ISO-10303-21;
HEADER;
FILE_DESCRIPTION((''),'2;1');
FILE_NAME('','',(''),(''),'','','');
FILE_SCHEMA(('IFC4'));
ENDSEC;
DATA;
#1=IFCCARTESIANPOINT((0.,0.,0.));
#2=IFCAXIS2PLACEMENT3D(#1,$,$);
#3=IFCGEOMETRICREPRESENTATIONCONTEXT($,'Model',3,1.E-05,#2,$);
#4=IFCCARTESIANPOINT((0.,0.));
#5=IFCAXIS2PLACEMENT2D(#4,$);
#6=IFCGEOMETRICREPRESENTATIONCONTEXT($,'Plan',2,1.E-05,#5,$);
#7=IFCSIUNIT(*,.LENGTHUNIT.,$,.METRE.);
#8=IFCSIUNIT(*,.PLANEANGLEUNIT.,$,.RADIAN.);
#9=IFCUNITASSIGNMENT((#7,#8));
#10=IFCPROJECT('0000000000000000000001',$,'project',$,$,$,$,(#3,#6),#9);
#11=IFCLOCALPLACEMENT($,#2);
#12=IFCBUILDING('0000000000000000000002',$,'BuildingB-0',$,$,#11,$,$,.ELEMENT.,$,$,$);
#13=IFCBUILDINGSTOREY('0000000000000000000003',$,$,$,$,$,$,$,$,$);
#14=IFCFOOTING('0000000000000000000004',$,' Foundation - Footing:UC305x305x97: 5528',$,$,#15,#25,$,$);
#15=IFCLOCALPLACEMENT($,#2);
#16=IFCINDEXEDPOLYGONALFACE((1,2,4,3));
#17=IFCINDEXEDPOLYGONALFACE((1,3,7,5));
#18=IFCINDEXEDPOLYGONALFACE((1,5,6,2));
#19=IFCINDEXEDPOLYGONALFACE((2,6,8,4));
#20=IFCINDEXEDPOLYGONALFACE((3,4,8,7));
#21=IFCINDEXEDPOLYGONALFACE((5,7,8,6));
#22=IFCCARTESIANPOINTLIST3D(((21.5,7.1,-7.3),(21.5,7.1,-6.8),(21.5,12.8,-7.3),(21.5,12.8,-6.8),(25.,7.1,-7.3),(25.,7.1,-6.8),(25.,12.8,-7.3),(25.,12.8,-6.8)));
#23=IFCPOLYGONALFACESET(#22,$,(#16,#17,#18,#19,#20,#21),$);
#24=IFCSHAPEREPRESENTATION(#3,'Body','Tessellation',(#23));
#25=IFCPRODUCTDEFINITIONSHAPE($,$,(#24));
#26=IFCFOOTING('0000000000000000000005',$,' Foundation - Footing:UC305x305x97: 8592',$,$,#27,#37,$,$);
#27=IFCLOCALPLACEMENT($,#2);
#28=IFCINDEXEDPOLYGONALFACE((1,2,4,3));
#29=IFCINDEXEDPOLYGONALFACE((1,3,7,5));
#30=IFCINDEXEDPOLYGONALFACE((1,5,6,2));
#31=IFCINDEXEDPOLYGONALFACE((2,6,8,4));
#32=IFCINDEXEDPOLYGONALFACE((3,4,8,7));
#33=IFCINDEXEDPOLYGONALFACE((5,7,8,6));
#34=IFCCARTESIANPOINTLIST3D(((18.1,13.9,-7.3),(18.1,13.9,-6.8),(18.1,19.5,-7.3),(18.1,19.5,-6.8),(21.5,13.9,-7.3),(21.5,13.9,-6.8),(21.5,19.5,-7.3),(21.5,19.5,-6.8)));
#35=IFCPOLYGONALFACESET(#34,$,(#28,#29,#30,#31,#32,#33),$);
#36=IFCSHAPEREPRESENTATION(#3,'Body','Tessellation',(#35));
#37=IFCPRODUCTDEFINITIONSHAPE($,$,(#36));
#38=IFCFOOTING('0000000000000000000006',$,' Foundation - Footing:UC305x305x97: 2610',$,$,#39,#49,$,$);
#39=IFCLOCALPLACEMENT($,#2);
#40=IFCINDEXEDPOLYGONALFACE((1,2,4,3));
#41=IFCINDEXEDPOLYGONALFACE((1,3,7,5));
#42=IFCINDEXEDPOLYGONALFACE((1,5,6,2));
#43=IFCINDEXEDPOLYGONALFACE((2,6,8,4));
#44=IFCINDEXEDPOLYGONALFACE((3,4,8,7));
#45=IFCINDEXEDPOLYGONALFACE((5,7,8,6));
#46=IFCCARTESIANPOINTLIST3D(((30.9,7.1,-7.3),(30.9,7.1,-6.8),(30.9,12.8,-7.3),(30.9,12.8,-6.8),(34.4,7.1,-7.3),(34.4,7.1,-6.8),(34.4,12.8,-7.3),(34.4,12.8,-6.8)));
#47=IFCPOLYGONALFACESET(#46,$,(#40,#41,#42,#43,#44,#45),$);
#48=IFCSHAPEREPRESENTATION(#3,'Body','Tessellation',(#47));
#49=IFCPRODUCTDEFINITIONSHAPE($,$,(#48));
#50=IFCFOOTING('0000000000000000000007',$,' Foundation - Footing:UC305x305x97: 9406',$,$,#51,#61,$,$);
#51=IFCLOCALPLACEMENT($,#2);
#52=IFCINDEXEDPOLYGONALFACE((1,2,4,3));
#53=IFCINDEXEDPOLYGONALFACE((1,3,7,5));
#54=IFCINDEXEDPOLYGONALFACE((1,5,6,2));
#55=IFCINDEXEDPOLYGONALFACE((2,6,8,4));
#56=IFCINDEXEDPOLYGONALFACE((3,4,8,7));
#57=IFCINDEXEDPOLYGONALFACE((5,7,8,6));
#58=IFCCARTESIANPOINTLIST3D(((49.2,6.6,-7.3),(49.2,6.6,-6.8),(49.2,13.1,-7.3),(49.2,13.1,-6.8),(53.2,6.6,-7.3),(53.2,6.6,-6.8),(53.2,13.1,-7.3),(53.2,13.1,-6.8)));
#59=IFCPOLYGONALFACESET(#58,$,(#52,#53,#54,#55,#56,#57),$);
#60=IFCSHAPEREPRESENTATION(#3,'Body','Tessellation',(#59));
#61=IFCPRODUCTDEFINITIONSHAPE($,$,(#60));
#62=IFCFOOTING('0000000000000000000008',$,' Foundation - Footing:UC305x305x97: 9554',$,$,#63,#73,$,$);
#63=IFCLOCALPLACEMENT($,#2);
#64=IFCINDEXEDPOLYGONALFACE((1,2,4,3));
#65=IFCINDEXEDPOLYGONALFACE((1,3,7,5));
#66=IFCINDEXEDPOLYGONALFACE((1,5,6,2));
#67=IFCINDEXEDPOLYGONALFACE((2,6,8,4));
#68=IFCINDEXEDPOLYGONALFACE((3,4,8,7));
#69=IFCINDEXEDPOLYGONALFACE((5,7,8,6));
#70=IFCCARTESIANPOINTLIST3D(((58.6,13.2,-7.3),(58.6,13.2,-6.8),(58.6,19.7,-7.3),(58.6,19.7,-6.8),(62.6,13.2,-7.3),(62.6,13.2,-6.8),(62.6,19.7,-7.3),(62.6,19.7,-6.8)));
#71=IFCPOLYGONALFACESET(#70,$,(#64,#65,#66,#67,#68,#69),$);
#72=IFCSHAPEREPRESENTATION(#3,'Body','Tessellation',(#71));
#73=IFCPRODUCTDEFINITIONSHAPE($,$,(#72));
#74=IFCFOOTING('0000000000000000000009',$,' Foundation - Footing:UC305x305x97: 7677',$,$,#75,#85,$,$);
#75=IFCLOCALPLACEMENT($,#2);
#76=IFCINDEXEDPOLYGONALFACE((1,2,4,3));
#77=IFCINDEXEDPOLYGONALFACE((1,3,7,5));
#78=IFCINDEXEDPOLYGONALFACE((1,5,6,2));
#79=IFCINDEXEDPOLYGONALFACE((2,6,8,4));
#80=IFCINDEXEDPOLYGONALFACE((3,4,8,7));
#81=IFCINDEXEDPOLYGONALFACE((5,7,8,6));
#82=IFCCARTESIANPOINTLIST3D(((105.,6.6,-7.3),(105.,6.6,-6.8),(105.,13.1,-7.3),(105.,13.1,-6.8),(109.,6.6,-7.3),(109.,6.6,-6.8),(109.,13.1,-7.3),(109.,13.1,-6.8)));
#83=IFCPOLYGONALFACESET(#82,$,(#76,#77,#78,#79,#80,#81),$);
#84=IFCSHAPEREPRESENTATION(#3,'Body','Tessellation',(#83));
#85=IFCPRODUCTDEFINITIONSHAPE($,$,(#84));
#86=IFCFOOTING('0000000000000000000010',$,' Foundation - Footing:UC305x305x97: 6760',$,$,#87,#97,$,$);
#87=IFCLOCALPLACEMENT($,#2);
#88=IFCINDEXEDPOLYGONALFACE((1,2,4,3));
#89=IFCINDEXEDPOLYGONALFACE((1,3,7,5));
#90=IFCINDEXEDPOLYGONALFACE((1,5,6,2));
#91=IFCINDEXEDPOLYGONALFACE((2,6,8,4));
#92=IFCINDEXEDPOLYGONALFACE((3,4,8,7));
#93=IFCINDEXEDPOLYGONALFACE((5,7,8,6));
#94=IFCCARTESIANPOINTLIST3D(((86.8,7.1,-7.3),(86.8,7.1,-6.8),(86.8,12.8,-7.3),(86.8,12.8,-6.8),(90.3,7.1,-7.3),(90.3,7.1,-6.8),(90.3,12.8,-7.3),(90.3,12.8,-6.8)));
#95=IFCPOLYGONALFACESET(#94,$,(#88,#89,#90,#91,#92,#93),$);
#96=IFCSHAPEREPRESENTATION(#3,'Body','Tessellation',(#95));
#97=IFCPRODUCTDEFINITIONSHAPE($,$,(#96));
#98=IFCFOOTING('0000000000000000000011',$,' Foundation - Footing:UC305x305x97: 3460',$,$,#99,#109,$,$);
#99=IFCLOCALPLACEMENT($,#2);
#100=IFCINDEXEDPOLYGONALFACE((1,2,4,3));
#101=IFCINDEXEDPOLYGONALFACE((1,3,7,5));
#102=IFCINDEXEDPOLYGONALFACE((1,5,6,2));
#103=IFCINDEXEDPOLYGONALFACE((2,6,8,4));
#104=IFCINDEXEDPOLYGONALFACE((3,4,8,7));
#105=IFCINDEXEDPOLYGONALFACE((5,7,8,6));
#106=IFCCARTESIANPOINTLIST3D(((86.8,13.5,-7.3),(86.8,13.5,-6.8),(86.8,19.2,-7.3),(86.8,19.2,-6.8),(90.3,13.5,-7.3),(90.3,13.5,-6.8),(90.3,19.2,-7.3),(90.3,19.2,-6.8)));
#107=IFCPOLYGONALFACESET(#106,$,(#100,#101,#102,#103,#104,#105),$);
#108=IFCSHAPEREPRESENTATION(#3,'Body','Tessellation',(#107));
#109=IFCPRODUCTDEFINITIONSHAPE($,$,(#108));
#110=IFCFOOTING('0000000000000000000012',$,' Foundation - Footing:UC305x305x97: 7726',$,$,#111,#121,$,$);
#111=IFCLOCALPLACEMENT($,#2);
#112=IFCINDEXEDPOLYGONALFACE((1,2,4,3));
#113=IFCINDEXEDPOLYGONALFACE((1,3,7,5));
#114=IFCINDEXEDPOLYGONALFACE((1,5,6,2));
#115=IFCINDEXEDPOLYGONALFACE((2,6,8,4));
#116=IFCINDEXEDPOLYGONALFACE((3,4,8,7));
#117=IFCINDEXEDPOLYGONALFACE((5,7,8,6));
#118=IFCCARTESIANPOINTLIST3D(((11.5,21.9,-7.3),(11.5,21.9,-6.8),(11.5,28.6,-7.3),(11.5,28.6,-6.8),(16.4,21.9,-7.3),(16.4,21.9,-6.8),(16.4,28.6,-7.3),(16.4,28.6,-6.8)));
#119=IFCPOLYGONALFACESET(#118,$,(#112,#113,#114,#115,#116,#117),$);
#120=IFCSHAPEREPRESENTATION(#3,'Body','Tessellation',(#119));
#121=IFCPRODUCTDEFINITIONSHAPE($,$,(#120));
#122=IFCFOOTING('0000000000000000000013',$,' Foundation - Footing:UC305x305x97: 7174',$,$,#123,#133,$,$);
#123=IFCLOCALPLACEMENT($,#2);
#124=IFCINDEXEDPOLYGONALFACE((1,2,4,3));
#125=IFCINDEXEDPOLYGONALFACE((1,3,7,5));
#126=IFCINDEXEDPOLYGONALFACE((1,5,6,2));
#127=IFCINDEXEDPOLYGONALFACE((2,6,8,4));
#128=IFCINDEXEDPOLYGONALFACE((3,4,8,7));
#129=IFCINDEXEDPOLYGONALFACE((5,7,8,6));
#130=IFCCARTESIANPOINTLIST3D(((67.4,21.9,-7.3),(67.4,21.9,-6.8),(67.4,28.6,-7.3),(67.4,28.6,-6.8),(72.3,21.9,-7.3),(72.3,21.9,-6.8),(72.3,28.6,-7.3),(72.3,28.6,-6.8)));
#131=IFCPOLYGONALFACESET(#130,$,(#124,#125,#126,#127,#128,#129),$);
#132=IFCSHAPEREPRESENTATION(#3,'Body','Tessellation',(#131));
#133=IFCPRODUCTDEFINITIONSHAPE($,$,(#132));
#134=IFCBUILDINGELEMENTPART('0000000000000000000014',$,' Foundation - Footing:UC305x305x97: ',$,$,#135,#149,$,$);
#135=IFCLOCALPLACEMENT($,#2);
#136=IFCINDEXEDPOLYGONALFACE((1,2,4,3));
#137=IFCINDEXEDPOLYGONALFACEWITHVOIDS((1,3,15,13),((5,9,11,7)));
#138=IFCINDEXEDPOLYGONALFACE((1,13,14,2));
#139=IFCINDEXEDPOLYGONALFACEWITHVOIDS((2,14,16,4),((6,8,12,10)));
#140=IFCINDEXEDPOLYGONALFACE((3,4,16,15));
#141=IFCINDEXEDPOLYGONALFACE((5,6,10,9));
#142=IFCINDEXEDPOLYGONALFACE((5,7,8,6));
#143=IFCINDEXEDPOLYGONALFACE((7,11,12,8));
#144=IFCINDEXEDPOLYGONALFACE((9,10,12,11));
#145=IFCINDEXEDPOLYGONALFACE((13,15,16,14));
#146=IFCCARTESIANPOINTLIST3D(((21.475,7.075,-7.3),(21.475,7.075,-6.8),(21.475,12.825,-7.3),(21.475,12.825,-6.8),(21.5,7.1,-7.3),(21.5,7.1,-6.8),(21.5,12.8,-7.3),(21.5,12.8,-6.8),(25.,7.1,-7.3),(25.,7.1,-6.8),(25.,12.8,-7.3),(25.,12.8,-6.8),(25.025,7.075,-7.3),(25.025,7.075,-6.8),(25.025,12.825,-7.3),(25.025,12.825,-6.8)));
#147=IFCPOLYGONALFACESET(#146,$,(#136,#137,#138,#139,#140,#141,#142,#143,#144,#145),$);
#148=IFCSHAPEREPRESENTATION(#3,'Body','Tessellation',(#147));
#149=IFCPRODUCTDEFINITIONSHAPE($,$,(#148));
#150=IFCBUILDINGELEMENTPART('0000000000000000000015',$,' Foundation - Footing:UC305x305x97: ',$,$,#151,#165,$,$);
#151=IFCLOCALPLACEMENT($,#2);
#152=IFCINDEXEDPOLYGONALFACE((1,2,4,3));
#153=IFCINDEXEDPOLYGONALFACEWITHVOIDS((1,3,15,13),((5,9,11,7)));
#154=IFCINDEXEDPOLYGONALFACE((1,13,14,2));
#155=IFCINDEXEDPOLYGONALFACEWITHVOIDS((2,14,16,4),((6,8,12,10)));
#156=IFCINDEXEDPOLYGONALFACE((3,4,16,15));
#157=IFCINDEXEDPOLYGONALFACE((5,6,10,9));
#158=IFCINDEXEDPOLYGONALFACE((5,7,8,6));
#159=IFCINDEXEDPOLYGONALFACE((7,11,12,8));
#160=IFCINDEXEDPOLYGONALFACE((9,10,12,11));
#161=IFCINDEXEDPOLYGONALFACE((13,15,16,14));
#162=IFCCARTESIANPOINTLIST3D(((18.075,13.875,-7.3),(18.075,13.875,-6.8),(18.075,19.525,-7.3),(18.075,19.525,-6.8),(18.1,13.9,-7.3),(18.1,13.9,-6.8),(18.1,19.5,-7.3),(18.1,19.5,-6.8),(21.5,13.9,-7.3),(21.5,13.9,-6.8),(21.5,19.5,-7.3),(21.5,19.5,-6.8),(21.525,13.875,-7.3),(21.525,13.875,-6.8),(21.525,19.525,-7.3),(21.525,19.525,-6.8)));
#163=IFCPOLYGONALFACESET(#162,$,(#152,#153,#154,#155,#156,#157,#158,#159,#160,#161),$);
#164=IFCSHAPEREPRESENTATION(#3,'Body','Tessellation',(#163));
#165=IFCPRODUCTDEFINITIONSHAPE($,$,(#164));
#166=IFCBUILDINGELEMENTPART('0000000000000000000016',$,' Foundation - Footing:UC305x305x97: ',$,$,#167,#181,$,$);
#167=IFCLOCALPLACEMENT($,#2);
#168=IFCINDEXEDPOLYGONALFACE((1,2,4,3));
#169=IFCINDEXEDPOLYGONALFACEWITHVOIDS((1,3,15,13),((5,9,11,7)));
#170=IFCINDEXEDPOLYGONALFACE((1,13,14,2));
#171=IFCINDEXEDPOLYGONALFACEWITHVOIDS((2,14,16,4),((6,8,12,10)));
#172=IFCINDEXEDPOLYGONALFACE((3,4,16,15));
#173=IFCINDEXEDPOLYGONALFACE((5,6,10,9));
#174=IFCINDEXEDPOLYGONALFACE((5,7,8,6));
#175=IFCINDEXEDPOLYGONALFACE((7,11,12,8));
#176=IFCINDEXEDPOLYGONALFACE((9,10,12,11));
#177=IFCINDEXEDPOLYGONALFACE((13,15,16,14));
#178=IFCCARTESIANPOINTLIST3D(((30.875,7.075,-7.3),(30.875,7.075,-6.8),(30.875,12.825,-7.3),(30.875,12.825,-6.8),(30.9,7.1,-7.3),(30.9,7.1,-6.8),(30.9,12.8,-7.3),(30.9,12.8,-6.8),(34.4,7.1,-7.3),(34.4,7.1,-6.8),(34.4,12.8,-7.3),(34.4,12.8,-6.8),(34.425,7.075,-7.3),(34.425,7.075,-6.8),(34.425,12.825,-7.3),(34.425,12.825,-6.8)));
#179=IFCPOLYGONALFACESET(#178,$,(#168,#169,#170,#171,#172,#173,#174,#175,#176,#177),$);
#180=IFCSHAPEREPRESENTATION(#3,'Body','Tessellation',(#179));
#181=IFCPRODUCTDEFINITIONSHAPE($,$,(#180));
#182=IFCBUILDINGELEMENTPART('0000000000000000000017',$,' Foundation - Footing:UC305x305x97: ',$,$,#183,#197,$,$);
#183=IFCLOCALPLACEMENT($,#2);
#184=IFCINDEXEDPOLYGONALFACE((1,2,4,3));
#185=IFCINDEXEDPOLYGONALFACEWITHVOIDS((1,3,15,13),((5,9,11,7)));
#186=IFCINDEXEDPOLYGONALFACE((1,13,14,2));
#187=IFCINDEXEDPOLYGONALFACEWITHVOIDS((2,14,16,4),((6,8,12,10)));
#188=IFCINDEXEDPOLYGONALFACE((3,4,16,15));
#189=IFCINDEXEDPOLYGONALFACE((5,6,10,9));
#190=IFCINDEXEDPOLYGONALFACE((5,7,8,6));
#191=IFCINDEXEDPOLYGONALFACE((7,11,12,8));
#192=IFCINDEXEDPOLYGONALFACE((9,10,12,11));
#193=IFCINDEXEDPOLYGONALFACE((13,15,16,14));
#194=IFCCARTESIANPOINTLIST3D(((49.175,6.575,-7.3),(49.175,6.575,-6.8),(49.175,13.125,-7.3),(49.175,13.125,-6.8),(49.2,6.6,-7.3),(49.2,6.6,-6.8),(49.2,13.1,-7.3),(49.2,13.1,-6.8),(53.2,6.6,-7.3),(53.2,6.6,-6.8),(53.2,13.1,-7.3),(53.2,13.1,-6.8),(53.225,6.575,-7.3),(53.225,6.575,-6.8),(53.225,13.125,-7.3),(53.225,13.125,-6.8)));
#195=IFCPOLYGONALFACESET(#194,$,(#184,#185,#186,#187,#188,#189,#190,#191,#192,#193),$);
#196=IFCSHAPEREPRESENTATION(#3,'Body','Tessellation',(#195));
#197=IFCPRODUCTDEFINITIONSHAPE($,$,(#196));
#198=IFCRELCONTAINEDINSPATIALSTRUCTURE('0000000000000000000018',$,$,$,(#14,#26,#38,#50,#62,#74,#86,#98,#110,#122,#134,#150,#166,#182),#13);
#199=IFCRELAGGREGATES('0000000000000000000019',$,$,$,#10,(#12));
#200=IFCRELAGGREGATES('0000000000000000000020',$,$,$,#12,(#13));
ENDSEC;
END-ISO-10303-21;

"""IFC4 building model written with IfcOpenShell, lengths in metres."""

from ifc_helpers import new_model, si_unit, origin, origin_2d, place, context, project, spatial, polyline, outline, extrude, element, save


model = new_model("IFC4")

# Units and contexts
model_context = context("Model", 3, precision=1e-05, world=origin())
plan_context = context("Plan", 2, precision=1e-05, world=origin_2d())
ifc_project = project(units=[si_unit("LENGTHUNIT", "METRE"), si_unit("PLANEANGLEUNIT", "RADIAN")], contexts=[model_context, plan_context])

# Building, storey
building_placement = place(None, origin())
building = spatial("IfcBuilding", under=ifc_project, at=building_placement, Name="BuildingB-0", CompositionType="ELEMENT")
storey = spatial("IfcBuildingStorey", under=building)

# Footings
element("IfcFooting", 1, inside=storey, Name=" Foundation - Footing:UC305x305x97: 5528", context=model_context, shape_type="SweptSolid", body=[
    extrude(outline(polyline([(25.0, 12.8, -7.3), (21.5, 12.8, -7.3), (21.5, 7.1, -7.3), (25.0, 7.1, -7.3), (25.0, 12.8, -7.3)])), None, (0.0, 0.0, 1.0), 0.5),
])
element("IfcFooting", 2, inside=storey, Name=" Foundation - Footing:UC305x305x97: 8592", context=model_context, shape_type="SweptSolid", body=[
    extrude(outline(polyline([(21.5, 19.5, -7.3), (18.1, 19.5, -7.3), (18.1, 13.9, -7.3), (21.5, 13.9, -7.3), (21.5, 19.5, -7.3)])), None, (0.0, 0.0, 1.0), 0.5),
])
element("IfcFooting", 3, inside=storey, Name=" Foundation - Footing:UC305x305x97: 2610", context=model_context, shape_type="SweptSolid", body=[
    extrude(outline(polyline([(34.4, 12.8, -7.3), (30.9, 12.8, -7.3), (30.9, 7.1, -7.3), (34.4, 7.1, -7.3), (34.4, 12.8, -7.3)])), None, (0.0, 0.0, 1.0), 0.5),
])
element("IfcFooting", 4, inside=storey, Name=" Foundation - Footing:UC305x305x97: 9406", context=model_context, shape_type="SweptSolid", body=[
    extrude(outline(polyline([(53.2, 13.1, -7.3), (49.2, 13.1, -7.3), (49.2, 6.6, -7.3), (53.2, 6.6, -7.3), (53.2, 13.1, -7.3)])), None, (0.0, 0.0, 1.0), 0.5),
])
element("IfcFooting", 5, inside=storey, Name=" Foundation - Footing:UC305x305x97: 9554", context=model_context, shape_type="SweptSolid", body=[
    extrude(outline(polyline([(58.6, 19.7, -7.3), (62.6, 19.7, -7.3), (62.6, 13.2, -7.3), (58.6, 13.2, -7.3), (58.6, 19.7, -7.3)])), None, (0.0, 0.0, 1.0), 0.5),
])
element("IfcFooting", 6, inside=storey, Name=" Foundation - Footing:UC305x305x97: 7677", context=model_context, shape_type="SweptSolid", body=[
    extrude(outline(polyline([(109.0, 13.1, -7.3), (105.0, 13.1, -7.3), (105.0, 6.6, -7.3), (109.0, 6.6, -7.3), (109.0, 13.1, -7.3)])), None, (0.0, 0.0, 1.0), 0.5),
])
element("IfcFooting", 7, inside=storey, Name=" Foundation - Footing:UC305x305x97: 6760", context=model_context, shape_type="SweptSolid", body=[
    extrude(outline(polyline([(86.8, 12.8, -7.3), (90.3, 12.8, -7.3), (90.3, 7.1, -7.3), (86.8, 7.1, -7.3), (86.8, 12.8, -7.3)])), None, (0.0, 0.0, 1.0), 0.5),
])
element("IfcFooting", 8, inside=storey, Name=" Foundation - Footing:UC305x305x97: 3460", context=model_context, shape_type="SweptSolid", body=[
    extrude(outline(polyline([(86.8, 19.2, -7.3), (90.3, 19.2, -7.3), (90.3, 13.5, -7.3), (86.8, 13.5, -7.3), (86.8, 19.2, -7.3)])), None, (0.0, 0.0, 1.0), 0.5),
])
element("IfcFooting", 9, inside=storey, Name=" Foundation - Footing:UC305x305x97: 7726", context=model_context, shape_type="SweptSolid", body=[
    extrude(outline(polyline([(16.4, 21.9, -7.3), (16.4, 28.6, -7.3), (11.5, 28.6, -7.3), (11.5, 21.9, -7.3), (16.4, 21.9, -7.3)])), None, (0.0, 0.0, 1.0), 0.5),
])
element("IfcFooting", 10, inside=storey, Name=" Foundation - Footing:UC305x305x97: 7174", context=model_context, shape_type="SweptSolid", body=[
    extrude(outline(polyline([(67.4, 21.9, -7.3), (67.4, 28.6, -7.3), (72.3, 28.6, -7.3), (72.3, 21.9, -7.3), (67.4, 21.9, -7.3)])), None, (0.0, 0.0, 1.0), 0.5),
])

# Building element parts, openings
building_element_part_1 = element("IfcBuildingElementPart", 11, inside=storey, Name=" Foundation - Footing:UC305x305x97: ", context=model_context, shape_type="SweptSolid", body=[
    extrude(outline(polyline([(25.025, 12.825, -7.3), (21.475, 12.825, -7.3), (21.475, 7.075, -7.3), (25.025, 7.075, -7.3), (25.025, 12.825, -7.3)])), None, (0.0, 0.0, 1.0), 0.5),
])
element("IfcOpeningElement", 12, inside=storey, cuts=building_element_part_1, context=model_context, shape_type="SweptSolid", body=[
    extrude(outline(polyline([(25.0, 12.8, -7.3), (21.5, 12.8, -7.3), (21.5, 7.1, -7.3), (25.0, 7.1, -7.3), (25.0, 12.8, -7.3)])), None, (0.0, 0.0, 1.0), 0.5),
])
building_element_part_2 = element("IfcBuildingElementPart", 13, inside=storey, Name=" Foundation - Footing:UC305x305x97: ", context=model_context, shape_type="SweptSolid", body=[
    extrude(outline(polyline([(21.525, 19.525, -7.3), (18.075, 19.525, -7.3), (18.075, 13.875, -7.3), (21.525, 13.875, -7.3), (21.525, 19.525, -7.3)])), None, (0.0, 0.0, 1.0), 0.5),
])
element("IfcOpeningElement", 14, inside=storey, cuts=building_element_part_2, context=model_context, shape_type="SweptSolid", body=[
    extrude(outline(polyline([(21.5, 19.5, -7.3), (18.1, 19.5, -7.3), (18.1, 13.9, -7.3), (21.5, 13.9, -7.3), (21.5, 19.5, -7.3)])), None, (0.0, 0.0, 1.0), 0.5),
])
building_element_part_3 = element("IfcBuildingElementPart", 15, inside=storey, Name=" Foundation - Footing:UC305x305x97: ", context=model_context, shape_type="SweptSolid", body=[
    extrude(outline(polyline([(34.425, 12.825, -7.3), (30.875, 12.825, -7.3), (30.875, 7.075, -7.3), (34.425, 7.075, -7.3), (34.425, 12.825, -7.3)])), None, (0.0, 0.0, 1.0), 0.5),
])
element("IfcOpeningElement", 16, inside=storey, cuts=building_element_part_3, context=model_context, shape_type="SweptSolid", body=[
    extrude(outline(polyline([(34.4, 12.8, -7.3), (30.9, 12.8, -7.3), (30.9, 7.1, -7.3), (34.4, 7.1, -7.3), (34.4, 12.8, -7.3)])), None, (0.0, 0.0, 1.0), 0.5),
])
building_element_part_4 = element("IfcBuildingElementPart", 17, inside=storey, Name=" Foundation - Footing:UC305x305x97: ", context=model_context, shape_type="SweptSolid", body=[
    extrude(outline(polyline([(53.225, 13.125, -7.3), (49.175, 13.125, -7.3), (49.175, 6.575, -7.3), (53.225, 6.575, -7.3), (53.225, 13.125, -7.3)])), None, (0.0, 0.0, 1.0), 0.5),
])
element("IfcOpeningElement", 18, inside=storey, cuts=building_element_part_4, context=model_context, shape_type="SweptSolid", body=[
    extrude(outline(polyline([(53.2, 13.1, -7.3), (49.2, 13.1, -7.3), (49.2, 6.6, -7.3), (53.2, 6.6, -7.3), (53.2, 13.1, -7.3)])), None, (0.0, 0.0, 1.0), 0.5),
])

save(model, "model.ifc")
